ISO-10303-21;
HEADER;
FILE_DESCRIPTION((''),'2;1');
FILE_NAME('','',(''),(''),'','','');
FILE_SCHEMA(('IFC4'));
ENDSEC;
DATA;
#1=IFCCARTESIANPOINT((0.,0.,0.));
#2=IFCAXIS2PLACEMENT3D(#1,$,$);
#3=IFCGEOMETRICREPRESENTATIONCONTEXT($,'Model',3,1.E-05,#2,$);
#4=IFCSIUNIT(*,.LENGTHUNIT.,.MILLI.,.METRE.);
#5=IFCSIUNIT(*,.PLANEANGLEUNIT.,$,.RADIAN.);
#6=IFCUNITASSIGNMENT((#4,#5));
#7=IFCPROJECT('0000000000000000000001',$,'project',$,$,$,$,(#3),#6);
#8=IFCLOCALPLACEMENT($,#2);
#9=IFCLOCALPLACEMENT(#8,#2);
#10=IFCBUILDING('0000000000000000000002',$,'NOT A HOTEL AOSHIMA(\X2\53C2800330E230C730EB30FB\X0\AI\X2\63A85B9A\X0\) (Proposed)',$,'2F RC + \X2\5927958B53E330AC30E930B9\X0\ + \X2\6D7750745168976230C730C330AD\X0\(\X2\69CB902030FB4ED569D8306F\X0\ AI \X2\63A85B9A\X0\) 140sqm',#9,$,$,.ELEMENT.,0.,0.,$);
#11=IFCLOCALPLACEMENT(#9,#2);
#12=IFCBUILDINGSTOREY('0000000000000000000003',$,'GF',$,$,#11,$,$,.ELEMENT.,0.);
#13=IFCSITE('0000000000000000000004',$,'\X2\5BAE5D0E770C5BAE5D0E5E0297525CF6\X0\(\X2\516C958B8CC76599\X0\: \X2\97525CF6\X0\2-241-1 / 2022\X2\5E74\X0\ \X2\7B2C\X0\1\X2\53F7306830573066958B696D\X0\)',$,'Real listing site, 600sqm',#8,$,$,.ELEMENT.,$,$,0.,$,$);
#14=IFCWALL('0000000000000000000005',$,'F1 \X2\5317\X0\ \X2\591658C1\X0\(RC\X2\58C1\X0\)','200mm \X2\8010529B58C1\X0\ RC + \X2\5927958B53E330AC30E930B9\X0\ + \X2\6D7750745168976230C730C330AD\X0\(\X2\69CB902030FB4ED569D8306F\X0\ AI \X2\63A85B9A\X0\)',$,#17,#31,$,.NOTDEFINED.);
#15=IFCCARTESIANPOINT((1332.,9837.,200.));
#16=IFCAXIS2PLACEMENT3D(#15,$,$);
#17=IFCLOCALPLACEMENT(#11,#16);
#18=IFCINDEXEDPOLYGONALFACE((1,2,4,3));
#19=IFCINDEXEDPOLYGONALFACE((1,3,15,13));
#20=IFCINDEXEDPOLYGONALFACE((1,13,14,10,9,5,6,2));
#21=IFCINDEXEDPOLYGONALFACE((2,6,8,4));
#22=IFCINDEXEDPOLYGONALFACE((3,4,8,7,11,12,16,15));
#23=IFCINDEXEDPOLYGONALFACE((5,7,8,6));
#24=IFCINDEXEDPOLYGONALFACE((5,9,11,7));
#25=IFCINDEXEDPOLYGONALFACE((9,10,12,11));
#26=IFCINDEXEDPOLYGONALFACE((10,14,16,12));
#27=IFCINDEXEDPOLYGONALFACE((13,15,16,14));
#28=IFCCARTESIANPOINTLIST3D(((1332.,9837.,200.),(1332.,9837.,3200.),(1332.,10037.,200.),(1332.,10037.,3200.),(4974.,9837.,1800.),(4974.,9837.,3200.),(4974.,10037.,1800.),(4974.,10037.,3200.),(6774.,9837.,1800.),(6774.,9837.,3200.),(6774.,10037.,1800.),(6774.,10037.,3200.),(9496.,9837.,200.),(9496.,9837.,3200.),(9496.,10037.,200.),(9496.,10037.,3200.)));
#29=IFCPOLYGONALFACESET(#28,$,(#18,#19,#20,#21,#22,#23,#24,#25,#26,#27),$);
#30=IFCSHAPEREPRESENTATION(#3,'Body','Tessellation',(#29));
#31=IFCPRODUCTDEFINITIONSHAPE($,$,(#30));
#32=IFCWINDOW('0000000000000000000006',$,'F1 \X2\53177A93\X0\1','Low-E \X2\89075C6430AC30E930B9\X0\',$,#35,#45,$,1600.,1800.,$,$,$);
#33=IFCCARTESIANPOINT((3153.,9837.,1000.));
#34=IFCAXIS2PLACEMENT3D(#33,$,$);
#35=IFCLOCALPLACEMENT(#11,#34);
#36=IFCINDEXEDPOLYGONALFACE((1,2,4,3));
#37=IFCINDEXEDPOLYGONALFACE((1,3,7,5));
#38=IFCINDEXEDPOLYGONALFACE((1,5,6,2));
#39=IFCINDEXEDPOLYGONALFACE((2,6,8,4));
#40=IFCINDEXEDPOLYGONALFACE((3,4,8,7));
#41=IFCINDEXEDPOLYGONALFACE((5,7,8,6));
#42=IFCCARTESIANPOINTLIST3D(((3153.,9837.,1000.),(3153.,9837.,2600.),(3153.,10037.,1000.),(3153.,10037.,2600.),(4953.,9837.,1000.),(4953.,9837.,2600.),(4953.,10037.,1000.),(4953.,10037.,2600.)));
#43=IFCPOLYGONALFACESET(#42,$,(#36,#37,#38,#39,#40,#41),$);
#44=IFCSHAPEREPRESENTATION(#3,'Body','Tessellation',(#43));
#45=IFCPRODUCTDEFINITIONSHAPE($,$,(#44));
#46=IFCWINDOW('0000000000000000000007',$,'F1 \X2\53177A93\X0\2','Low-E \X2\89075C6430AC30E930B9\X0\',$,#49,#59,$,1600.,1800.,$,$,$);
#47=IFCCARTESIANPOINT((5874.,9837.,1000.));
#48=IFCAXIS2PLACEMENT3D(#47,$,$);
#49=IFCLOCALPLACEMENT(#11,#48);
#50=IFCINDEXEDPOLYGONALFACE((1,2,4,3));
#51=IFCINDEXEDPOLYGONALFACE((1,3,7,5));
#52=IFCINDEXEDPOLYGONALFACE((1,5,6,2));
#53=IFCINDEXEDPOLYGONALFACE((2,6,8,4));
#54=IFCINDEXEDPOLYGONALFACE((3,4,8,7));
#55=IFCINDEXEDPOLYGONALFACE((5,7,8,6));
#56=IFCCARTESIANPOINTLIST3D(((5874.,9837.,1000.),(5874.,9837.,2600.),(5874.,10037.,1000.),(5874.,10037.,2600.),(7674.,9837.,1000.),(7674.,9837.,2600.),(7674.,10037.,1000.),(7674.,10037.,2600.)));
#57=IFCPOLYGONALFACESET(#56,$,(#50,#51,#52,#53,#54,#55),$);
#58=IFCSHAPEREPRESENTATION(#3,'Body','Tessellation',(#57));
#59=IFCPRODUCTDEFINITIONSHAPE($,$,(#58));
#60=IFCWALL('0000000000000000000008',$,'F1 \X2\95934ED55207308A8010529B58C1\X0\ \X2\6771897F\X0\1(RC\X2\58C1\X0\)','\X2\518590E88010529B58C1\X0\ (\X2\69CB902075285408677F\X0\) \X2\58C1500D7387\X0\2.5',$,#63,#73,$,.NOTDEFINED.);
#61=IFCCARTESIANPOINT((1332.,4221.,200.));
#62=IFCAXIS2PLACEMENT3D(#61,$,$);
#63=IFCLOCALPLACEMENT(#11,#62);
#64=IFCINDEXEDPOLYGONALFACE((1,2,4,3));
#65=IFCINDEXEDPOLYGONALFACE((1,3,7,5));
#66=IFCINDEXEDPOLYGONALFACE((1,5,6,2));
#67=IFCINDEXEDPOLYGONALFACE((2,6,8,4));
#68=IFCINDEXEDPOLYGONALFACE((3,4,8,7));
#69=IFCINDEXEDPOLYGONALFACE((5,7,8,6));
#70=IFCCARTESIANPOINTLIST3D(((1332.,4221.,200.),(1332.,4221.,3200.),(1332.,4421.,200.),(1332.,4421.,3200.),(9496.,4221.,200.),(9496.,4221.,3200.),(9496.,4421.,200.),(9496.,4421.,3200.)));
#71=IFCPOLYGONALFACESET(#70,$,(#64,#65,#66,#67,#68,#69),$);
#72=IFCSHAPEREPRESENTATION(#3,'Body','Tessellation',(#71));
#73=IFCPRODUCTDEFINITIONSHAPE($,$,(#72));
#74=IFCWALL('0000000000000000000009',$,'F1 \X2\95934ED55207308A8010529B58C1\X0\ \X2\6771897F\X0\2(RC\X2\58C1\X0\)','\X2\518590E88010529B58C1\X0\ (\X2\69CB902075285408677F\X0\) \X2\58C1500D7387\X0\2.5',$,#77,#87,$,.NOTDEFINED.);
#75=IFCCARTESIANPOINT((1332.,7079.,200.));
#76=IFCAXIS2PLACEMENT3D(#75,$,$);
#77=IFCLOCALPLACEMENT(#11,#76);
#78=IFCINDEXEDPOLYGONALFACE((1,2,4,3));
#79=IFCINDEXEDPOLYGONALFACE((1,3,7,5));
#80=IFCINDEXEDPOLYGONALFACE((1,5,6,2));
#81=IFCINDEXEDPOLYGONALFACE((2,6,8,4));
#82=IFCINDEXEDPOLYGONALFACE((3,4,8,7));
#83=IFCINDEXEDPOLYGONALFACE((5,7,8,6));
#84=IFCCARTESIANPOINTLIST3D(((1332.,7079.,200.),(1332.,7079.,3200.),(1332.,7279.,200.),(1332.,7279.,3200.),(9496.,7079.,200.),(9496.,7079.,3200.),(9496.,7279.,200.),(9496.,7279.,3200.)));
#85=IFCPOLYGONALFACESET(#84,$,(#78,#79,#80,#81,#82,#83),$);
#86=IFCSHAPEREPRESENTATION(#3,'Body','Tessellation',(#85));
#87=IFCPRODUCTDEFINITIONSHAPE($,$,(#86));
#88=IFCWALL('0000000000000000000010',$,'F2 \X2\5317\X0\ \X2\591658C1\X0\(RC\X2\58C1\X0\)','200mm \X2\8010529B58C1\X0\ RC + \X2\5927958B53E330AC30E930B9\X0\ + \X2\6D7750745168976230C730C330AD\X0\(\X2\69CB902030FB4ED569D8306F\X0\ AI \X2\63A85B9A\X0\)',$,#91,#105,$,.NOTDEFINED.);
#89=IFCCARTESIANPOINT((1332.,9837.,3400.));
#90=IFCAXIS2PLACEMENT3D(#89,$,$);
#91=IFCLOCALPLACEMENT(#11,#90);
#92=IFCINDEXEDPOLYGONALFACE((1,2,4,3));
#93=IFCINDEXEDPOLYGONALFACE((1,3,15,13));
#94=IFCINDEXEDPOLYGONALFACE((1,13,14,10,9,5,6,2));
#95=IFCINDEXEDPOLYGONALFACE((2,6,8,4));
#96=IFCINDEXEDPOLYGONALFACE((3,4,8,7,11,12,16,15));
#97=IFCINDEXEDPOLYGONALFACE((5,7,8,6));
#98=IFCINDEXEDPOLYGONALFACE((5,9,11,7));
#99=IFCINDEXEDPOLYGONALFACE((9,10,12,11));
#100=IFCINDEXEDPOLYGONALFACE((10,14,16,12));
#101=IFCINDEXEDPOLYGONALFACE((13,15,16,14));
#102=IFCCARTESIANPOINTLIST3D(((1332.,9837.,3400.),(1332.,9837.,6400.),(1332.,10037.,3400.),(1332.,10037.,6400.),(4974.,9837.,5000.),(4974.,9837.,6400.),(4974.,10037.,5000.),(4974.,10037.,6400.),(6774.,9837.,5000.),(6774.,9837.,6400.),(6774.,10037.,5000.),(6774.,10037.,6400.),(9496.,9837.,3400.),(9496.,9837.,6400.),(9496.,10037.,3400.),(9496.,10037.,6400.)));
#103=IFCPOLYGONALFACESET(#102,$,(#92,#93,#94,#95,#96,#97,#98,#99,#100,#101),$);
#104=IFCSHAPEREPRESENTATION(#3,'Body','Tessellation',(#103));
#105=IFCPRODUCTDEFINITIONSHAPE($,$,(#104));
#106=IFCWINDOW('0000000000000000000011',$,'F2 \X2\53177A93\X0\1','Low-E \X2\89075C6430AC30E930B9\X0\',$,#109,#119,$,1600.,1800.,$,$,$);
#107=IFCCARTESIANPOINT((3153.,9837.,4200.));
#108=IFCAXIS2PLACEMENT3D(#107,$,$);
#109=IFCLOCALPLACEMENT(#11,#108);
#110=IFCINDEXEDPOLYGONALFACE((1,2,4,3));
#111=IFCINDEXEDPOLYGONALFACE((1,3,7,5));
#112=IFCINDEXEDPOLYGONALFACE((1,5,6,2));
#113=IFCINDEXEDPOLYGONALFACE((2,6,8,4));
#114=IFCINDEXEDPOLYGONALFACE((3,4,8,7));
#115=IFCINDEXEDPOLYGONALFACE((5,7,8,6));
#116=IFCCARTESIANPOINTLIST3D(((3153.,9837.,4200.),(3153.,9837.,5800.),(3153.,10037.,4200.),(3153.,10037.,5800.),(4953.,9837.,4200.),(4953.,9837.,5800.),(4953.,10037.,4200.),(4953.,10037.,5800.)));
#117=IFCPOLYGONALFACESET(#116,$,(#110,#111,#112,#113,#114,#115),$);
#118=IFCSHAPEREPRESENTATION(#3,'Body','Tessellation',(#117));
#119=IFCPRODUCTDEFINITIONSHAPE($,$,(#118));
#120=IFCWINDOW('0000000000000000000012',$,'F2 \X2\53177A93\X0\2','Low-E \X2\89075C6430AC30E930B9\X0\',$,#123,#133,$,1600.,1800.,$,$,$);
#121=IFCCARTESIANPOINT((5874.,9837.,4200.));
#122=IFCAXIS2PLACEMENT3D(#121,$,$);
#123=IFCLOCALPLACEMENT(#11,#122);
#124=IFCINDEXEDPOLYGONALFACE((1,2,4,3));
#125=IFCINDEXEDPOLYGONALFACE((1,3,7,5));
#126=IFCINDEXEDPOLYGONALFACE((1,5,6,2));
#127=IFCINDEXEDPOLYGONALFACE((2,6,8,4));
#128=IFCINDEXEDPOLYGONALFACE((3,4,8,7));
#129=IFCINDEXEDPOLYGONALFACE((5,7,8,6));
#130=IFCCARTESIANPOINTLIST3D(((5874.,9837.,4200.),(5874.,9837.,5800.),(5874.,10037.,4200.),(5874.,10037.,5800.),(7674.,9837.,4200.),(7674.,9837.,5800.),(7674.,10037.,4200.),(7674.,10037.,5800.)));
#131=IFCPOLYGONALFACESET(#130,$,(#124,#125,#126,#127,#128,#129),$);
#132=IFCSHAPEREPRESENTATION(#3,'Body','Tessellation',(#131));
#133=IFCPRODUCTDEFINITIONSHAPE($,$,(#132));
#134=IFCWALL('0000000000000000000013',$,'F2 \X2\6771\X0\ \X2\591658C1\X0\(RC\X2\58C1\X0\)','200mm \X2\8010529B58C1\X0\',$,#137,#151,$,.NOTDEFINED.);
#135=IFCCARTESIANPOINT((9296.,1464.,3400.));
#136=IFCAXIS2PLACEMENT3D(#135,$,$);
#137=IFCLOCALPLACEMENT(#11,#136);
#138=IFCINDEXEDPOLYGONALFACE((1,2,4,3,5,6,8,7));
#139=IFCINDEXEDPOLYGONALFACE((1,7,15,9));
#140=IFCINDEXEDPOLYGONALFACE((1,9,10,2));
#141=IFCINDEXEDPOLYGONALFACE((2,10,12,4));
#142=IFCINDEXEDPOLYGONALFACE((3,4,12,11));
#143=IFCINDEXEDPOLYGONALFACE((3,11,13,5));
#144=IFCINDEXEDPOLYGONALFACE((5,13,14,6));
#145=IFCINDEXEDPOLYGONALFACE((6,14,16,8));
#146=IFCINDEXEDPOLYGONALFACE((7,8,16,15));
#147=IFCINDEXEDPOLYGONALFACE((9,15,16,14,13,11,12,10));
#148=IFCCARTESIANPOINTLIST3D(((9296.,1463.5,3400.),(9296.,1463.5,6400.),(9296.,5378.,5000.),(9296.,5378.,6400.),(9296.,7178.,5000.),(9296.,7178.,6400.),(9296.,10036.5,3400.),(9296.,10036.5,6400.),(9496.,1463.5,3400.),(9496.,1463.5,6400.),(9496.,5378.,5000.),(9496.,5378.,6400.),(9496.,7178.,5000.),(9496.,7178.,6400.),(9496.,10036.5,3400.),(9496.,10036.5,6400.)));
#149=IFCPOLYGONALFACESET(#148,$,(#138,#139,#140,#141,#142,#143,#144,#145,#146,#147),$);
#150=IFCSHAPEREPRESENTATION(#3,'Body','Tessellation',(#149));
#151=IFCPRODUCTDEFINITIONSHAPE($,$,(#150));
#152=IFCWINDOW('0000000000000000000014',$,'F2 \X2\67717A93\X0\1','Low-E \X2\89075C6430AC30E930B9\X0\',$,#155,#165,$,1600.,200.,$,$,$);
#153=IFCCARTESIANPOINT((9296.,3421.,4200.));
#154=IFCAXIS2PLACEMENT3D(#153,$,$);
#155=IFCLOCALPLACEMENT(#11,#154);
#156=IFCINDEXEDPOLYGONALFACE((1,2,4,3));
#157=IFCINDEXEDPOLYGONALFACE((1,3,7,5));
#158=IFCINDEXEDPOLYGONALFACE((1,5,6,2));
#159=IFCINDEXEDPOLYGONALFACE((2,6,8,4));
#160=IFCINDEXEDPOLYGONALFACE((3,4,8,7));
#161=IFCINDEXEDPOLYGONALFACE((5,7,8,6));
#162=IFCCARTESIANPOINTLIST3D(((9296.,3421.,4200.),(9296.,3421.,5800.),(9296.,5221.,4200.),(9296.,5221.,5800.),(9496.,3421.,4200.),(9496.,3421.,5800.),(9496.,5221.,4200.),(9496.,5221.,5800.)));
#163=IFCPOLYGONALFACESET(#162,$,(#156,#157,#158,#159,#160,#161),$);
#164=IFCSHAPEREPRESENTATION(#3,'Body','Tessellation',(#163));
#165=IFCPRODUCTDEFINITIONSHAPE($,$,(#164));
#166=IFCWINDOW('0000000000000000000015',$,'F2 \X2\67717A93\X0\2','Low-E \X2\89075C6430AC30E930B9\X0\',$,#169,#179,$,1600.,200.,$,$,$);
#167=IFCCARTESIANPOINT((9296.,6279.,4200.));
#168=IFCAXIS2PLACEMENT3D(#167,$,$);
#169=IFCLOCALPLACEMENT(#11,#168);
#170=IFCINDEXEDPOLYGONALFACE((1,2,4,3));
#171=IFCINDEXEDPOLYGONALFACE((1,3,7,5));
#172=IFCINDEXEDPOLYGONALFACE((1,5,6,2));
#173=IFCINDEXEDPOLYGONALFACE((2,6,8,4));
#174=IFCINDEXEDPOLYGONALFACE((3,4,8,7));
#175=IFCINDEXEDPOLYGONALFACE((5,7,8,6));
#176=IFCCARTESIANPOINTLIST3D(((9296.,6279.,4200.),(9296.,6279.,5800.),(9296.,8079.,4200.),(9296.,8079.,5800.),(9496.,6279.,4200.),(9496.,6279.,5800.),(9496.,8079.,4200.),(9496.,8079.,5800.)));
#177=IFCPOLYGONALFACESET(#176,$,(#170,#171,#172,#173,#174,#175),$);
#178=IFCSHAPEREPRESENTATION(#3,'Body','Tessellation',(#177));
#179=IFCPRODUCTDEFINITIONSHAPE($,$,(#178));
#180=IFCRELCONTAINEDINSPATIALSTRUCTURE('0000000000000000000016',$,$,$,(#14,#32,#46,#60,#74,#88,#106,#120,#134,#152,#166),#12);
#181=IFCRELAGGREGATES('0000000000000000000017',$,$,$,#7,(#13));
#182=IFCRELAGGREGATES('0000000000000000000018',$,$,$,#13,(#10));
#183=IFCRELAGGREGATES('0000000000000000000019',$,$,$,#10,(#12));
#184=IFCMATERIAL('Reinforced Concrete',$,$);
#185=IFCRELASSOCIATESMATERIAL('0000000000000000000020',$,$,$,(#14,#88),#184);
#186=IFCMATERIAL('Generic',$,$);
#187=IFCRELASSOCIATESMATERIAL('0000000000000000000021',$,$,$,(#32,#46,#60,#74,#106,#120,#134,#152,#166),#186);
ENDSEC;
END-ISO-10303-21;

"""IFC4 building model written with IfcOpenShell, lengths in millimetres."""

from ifc_helpers import new_model, si_unit, frame, frame_2d, origin, place, context, project, spatial, rectangle, extrude, material, element, fill, save


model = new_model("IFC4")

# Units and contexts
model_context = context("Model", 3, precision=1e-05, world=origin())
ifc_project = project(units=[si_unit("LENGTHUNIT", "METRE", prefix="MILLI"), si_unit("PLANEANGLEUNIT", "RADIAN")], contexts=[model_context])

# Site, building, storey
site_placement = place(None, origin())
site = spatial("IfcSite", under=ifc_project, at=site_placement, Name="宮崎県宮崎市青島(公開資料: 青島2-241-1 / 2022年 第1号として開業)", ObjectType="Real listing site, 600sqm", CompositionType="ELEMENT", RefElevation=0.0)
building_placement = place(site_placement, origin())
building = spatial("IfcBuilding", under=site, at=building_placement, Name="NOT A HOTEL AOSHIMA(参考モデル・AI推定) (Proposed)", ObjectType="2F RC + 大開口ガラス + 海側全面デッキ(構造・仕様は AI 推定) 140sqm", CompositionType="ELEMENT", ElevationOfRefHeight=0.0, ElevationOfTerrain=0.0)
storey_placement = place(building_placement, origin())
storey = spatial("IfcBuildingStorey", under=building, at=storey_placement, Name="GF", CompositionType="ELEMENT", Elevation=0.0)

# Wall, openings, windows
ifc_material_1 = material(Name="Reinforced Concrete")
wall_1_placement = place(storey_placement, frame((1332.0, 9837.0, 200.0)))
wall_1 = element("IfcWall", 1, at=wall_1_placement, inside=storey, material=ifc_material_1, Name="F1 北 外壁(RC壁)", Description="200mm 耐力壁 RC + 大開口ガラス + 海側全面デッキ(構造・仕様は AI 推定)", PredefinedType="NOTDEFINED", context=model_context, shape_type="SweptSolid", body=[
    extrude(rectangle(XDim=8164.0, YDim=200.0, at=frame_2d((4082.0, 100.0))), frame((1332.0, 9837.0, 200.0)), (0.0, 0.0, 1.0), 3000.0),
])
opening_1_placement = place(storey_placement, frame((3153.0, 9837.0, 1000.0)))
opening_1 = element("IfcOpeningElement", 2, at=opening_1_placement, cuts=wall_1, PredefinedType="NOTDEFINED", context=model_context, shape_type="SweptSolid", body=[
    extrude(rectangle(XDim=1800.0, YDim=200.0, at=frame_2d((900.0, 100.0))), frame((3153.0, 9837.0, 1000.0)), (0.0, 0.0, 1.0), 1600.0),
])
opening_2_placement = place(storey_placement, frame((5874.0, 9837.0, 1000.0)))
opening_2 = element("IfcOpeningElement", 3, at=opening_2_placement, cuts=wall_1, PredefinedType="NOTDEFINED", context=model_context, shape_type="SweptSolid", body=[
    extrude(rectangle(XDim=1800.0, YDim=200.0, at=frame_2d((900.0, 100.0))), frame((5874.0, 9837.0, 1000.0)), (0.0, 0.0, 1.0), 1600.0),
])
ifc_material_2 = material(Name="Generic")
window_1_placement = place(storey_placement, frame((3153.0, 9837.0, 1000.0)))
window_1 = element("IfcWindow", 4, at=window_1_placement, inside=storey, material=ifc_material_2, Name="F1 北窓1", Description="Low-E 複層ガラス", OverallHeight=1600.0, OverallWidth=1800.0, context=model_context, shape_type="SweptSolid", body=[
    extrude(rectangle(XDim=1800.0, YDim=200.0, at=frame_2d((900.0, 100.0))), frame((3153.0, 9837.0, 1000.0)), (0.0, 0.0, 1.0), 1600.0),
])
fill(opening_1, window_1)
window_2_placement = place(storey_placement, frame((5874.0, 9837.0, 1000.0)))
window_2 = element("IfcWindow", 5, at=window_2_placement, inside=storey, material=ifc_material_2, Name="F1 北窓2", Description="Low-E 複層ガラス", OverallHeight=1600.0, OverallWidth=1800.0, context=model_context, shape_type="SweptSolid", body=[
    extrude(rectangle(XDim=1800.0, YDim=200.0, at=frame_2d((900.0, 100.0))), frame((5874.0, 9837.0, 1000.0)), (0.0, 0.0, 1.0), 1600.0),
])
fill(opening_2, window_2)

# Walls
wall_2_placement = place(storey_placement, frame((1332.0, 4221.0, 200.0)))
element("IfcWall", 6, at=wall_2_placement, inside=storey, material=ifc_material_2, Name="F1 間仕切り耐力壁 東西1(RC壁)", Description="内部耐力壁 (構造用合板) 壁倍率2.5", PredefinedType="NOTDEFINED", context=model_context, shape_type="SweptSolid", body=[
    extrude(rectangle(XDim=8164.0, YDim=200.0, at=frame_2d((4082.0, 100.0))), frame((1332.0, 4221.0, 200.0)), (0.0, 0.0, 1.0), 3000.0),
])
wall_3_placement = place(storey_placement, frame((1332.0, 7079.0, 200.0)))
element("IfcWall", 7, at=wall_3_placement, inside=storey, material=ifc_material_2, Name="F1 間仕切り耐力壁 東西2(RC壁)", Description="内部耐力壁 (構造用合板) 壁倍率2.5", PredefinedType="NOTDEFINED", context=model_context, shape_type="SweptSolid", body=[
    extrude(rectangle(XDim=8164.0, YDim=200.0, at=frame_2d((4082.0, 100.0))), frame((1332.0, 7079.0, 200.0)), (0.0, 0.0, 1.0), 3000.0),
])

# Walls, openings, windows
wall_4_placement = place(storey_placement, frame((1332.0, 9837.0, 3400.0)))
wall_4 = element("IfcWall", 8, at=wall_4_placement, inside=storey, material=ifc_material_1, Name="F2 北 外壁(RC壁)", Description="200mm 耐力壁 RC + 大開口ガラス + 海側全面デッキ(構造・仕様は AI 推定)", PredefinedType="NOTDEFINED", context=model_context, shape_type="SweptSolid", body=[
    extrude(rectangle(XDim=8164.0, YDim=200.0, at=frame_2d((4082.0, 100.0))), frame((1332.0, 9837.0, 3400.0)), (0.0, 0.0, 1.0), 3000.0),
])
opening_3_placement = place(storey_placement, frame((3153.0, 9837.0, 4200.0)))
opening_3 = element("IfcOpeningElement", 9, at=opening_3_placement, cuts=wall_4, PredefinedType="NOTDEFINED", context=model_context, shape_type="SweptSolid", body=[
    extrude(rectangle(XDim=1800.0, YDim=200.0, at=frame_2d((900.0, 100.0))), frame((3153.0, 9837.0, 4200.0)), (0.0, 0.0, 1.0), 1600.0),
])
opening_4_placement = place(storey_placement, frame((5874.0, 9837.0, 4200.0)))
opening_4 = element("IfcOpeningElement", 10, at=opening_4_placement, cuts=wall_4, PredefinedType="NOTDEFINED", context=model_context, shape_type="SweptSolid", body=[
    extrude(rectangle(XDim=1800.0, YDim=200.0, at=frame_2d((900.0, 100.0))), frame((5874.0, 9837.0, 4200.0)), (0.0, 0.0, 1.0), 1600.0),
])
window_3_placement = place(storey_placement, frame((3153.0, 9837.0, 4200.0)))
window_3 = element("IfcWindow", 11, at=window_3_placement, inside=storey, material=ifc_material_2, Name="F2 北窓1", Description="Low-E 複層ガラス", OverallHeight=1600.0, OverallWidth=1800.0, context=model_context, shape_type="SweptSolid", body=[
    extrude(rectangle(XDim=1800.0, YDim=200.0, at=frame_2d((900.0, 100.0))), frame((3153.0, 9837.0, 4200.0)), (0.0, 0.0, 1.0), 1600.0),
])
fill(opening_3, window_3)
window_4_placement = place(storey_placement, frame((5874.0, 9837.0, 4200.0)))
window_4 = element("IfcWindow", 12, at=window_4_placement, inside=storey, material=ifc_material_2, Name="F2 北窓2", Description="Low-E 複層ガラス", OverallHeight=1600.0, OverallWidth=1800.0, context=model_context, shape_type="SweptSolid", body=[
    extrude(rectangle(XDim=1800.0, YDim=200.0, at=frame_2d((900.0, 100.0))), frame((5874.0, 9837.0, 4200.0)), (0.0, 0.0, 1.0), 1600.0),
])
fill(opening_4, window_4)
wall_5_placement = place(storey_placement, frame((9296.0, 1464.0, 3400.0)))
wall_5 = element("IfcWall", 13, at=wall_5_placement, inside=storey, material=ifc_material_2, Name="F2 東 外壁(RC壁)", Description="200mm 耐力壁", PredefinedType="NOTDEFINED", context=model_context, shape_type="SweptSolid", body=[
    extrude(rectangle(XDim=200.0, YDim=8573.0, at=frame_2d((100.0, 4286.0))), frame((9296.0, 1464.0, 3400.0)), (0.0, 0.0, 1.0), 3000.0),
])
opening_5_placement = place(storey_placement, frame((9296.0, 3421.0, 4200.0)))
opening_5 = element("IfcOpeningElement", 14, at=opening_5_placement, cuts=wall_5, PredefinedType="NOTDEFINED", context=model_context, shape_type="SweptSolid", body=[
    extrude(rectangle(XDim=200.0, YDim=1800.0, at=frame_2d((100.0, 900.0))), frame((9296.0, 3421.0, 4200.0)), (0.0, 0.0, 1.0), 1600.0),
])
opening_6_placement = place(storey_placement, frame((9296.0, 6279.0, 4200.0)))
opening_6 = element("IfcOpeningElement", 15, at=opening_6_placement, cuts=wall_5, PredefinedType="NOTDEFINED", context=model_context, shape_type="SweptSolid", body=[
    extrude(rectangle(XDim=200.0, YDim=1800.0, at=frame_2d((100.0, 900.0))), frame((9296.0, 6279.0, 4200.0)), (0.0, 0.0, 1.0), 1600.0),
])
window_5_placement = place(storey_placement, frame((9296.0, 3421.0, 4200.0)))
window_5 = element("IfcWindow", 16, at=window_5_placement, inside=storey, material=ifc_material_2, Name="F2 東窓1", Description="Low-E 複層ガラス", OverallHeight=1600.0, OverallWidth=200.0, context=model_context, shape_type="SweptSolid", body=[
    extrude(rectangle(XDim=200.0, YDim=1800.0, at=frame_2d((100.0, 900.0))), frame((9296.0, 3421.0, 4200.0)), (0.0, 0.0, 1.0), 1600.0),
])
fill(opening_5, window_5)
window_6_placement = place(storey_placement, frame((9296.0, 6279.0, 4200.0)))
window_6 = element("IfcWindow", 17, at=window_6_placement, inside=storey, material=ifc_material_2, Name="F2 東窓2", Description="Low-E 複層ガラス", OverallHeight=1600.0, OverallWidth=200.0, context=model_context, shape_type="SweptSolid", body=[
    extrude(rectangle(XDim=200.0, YDim=1800.0, at=frame_2d((100.0, 900.0))), frame((9296.0, 6279.0, 4200.0)), (0.0, 0.0, 1.0), 1600.0),
])
fill(opening_6, window_6)

save(model, "model.ifc")
